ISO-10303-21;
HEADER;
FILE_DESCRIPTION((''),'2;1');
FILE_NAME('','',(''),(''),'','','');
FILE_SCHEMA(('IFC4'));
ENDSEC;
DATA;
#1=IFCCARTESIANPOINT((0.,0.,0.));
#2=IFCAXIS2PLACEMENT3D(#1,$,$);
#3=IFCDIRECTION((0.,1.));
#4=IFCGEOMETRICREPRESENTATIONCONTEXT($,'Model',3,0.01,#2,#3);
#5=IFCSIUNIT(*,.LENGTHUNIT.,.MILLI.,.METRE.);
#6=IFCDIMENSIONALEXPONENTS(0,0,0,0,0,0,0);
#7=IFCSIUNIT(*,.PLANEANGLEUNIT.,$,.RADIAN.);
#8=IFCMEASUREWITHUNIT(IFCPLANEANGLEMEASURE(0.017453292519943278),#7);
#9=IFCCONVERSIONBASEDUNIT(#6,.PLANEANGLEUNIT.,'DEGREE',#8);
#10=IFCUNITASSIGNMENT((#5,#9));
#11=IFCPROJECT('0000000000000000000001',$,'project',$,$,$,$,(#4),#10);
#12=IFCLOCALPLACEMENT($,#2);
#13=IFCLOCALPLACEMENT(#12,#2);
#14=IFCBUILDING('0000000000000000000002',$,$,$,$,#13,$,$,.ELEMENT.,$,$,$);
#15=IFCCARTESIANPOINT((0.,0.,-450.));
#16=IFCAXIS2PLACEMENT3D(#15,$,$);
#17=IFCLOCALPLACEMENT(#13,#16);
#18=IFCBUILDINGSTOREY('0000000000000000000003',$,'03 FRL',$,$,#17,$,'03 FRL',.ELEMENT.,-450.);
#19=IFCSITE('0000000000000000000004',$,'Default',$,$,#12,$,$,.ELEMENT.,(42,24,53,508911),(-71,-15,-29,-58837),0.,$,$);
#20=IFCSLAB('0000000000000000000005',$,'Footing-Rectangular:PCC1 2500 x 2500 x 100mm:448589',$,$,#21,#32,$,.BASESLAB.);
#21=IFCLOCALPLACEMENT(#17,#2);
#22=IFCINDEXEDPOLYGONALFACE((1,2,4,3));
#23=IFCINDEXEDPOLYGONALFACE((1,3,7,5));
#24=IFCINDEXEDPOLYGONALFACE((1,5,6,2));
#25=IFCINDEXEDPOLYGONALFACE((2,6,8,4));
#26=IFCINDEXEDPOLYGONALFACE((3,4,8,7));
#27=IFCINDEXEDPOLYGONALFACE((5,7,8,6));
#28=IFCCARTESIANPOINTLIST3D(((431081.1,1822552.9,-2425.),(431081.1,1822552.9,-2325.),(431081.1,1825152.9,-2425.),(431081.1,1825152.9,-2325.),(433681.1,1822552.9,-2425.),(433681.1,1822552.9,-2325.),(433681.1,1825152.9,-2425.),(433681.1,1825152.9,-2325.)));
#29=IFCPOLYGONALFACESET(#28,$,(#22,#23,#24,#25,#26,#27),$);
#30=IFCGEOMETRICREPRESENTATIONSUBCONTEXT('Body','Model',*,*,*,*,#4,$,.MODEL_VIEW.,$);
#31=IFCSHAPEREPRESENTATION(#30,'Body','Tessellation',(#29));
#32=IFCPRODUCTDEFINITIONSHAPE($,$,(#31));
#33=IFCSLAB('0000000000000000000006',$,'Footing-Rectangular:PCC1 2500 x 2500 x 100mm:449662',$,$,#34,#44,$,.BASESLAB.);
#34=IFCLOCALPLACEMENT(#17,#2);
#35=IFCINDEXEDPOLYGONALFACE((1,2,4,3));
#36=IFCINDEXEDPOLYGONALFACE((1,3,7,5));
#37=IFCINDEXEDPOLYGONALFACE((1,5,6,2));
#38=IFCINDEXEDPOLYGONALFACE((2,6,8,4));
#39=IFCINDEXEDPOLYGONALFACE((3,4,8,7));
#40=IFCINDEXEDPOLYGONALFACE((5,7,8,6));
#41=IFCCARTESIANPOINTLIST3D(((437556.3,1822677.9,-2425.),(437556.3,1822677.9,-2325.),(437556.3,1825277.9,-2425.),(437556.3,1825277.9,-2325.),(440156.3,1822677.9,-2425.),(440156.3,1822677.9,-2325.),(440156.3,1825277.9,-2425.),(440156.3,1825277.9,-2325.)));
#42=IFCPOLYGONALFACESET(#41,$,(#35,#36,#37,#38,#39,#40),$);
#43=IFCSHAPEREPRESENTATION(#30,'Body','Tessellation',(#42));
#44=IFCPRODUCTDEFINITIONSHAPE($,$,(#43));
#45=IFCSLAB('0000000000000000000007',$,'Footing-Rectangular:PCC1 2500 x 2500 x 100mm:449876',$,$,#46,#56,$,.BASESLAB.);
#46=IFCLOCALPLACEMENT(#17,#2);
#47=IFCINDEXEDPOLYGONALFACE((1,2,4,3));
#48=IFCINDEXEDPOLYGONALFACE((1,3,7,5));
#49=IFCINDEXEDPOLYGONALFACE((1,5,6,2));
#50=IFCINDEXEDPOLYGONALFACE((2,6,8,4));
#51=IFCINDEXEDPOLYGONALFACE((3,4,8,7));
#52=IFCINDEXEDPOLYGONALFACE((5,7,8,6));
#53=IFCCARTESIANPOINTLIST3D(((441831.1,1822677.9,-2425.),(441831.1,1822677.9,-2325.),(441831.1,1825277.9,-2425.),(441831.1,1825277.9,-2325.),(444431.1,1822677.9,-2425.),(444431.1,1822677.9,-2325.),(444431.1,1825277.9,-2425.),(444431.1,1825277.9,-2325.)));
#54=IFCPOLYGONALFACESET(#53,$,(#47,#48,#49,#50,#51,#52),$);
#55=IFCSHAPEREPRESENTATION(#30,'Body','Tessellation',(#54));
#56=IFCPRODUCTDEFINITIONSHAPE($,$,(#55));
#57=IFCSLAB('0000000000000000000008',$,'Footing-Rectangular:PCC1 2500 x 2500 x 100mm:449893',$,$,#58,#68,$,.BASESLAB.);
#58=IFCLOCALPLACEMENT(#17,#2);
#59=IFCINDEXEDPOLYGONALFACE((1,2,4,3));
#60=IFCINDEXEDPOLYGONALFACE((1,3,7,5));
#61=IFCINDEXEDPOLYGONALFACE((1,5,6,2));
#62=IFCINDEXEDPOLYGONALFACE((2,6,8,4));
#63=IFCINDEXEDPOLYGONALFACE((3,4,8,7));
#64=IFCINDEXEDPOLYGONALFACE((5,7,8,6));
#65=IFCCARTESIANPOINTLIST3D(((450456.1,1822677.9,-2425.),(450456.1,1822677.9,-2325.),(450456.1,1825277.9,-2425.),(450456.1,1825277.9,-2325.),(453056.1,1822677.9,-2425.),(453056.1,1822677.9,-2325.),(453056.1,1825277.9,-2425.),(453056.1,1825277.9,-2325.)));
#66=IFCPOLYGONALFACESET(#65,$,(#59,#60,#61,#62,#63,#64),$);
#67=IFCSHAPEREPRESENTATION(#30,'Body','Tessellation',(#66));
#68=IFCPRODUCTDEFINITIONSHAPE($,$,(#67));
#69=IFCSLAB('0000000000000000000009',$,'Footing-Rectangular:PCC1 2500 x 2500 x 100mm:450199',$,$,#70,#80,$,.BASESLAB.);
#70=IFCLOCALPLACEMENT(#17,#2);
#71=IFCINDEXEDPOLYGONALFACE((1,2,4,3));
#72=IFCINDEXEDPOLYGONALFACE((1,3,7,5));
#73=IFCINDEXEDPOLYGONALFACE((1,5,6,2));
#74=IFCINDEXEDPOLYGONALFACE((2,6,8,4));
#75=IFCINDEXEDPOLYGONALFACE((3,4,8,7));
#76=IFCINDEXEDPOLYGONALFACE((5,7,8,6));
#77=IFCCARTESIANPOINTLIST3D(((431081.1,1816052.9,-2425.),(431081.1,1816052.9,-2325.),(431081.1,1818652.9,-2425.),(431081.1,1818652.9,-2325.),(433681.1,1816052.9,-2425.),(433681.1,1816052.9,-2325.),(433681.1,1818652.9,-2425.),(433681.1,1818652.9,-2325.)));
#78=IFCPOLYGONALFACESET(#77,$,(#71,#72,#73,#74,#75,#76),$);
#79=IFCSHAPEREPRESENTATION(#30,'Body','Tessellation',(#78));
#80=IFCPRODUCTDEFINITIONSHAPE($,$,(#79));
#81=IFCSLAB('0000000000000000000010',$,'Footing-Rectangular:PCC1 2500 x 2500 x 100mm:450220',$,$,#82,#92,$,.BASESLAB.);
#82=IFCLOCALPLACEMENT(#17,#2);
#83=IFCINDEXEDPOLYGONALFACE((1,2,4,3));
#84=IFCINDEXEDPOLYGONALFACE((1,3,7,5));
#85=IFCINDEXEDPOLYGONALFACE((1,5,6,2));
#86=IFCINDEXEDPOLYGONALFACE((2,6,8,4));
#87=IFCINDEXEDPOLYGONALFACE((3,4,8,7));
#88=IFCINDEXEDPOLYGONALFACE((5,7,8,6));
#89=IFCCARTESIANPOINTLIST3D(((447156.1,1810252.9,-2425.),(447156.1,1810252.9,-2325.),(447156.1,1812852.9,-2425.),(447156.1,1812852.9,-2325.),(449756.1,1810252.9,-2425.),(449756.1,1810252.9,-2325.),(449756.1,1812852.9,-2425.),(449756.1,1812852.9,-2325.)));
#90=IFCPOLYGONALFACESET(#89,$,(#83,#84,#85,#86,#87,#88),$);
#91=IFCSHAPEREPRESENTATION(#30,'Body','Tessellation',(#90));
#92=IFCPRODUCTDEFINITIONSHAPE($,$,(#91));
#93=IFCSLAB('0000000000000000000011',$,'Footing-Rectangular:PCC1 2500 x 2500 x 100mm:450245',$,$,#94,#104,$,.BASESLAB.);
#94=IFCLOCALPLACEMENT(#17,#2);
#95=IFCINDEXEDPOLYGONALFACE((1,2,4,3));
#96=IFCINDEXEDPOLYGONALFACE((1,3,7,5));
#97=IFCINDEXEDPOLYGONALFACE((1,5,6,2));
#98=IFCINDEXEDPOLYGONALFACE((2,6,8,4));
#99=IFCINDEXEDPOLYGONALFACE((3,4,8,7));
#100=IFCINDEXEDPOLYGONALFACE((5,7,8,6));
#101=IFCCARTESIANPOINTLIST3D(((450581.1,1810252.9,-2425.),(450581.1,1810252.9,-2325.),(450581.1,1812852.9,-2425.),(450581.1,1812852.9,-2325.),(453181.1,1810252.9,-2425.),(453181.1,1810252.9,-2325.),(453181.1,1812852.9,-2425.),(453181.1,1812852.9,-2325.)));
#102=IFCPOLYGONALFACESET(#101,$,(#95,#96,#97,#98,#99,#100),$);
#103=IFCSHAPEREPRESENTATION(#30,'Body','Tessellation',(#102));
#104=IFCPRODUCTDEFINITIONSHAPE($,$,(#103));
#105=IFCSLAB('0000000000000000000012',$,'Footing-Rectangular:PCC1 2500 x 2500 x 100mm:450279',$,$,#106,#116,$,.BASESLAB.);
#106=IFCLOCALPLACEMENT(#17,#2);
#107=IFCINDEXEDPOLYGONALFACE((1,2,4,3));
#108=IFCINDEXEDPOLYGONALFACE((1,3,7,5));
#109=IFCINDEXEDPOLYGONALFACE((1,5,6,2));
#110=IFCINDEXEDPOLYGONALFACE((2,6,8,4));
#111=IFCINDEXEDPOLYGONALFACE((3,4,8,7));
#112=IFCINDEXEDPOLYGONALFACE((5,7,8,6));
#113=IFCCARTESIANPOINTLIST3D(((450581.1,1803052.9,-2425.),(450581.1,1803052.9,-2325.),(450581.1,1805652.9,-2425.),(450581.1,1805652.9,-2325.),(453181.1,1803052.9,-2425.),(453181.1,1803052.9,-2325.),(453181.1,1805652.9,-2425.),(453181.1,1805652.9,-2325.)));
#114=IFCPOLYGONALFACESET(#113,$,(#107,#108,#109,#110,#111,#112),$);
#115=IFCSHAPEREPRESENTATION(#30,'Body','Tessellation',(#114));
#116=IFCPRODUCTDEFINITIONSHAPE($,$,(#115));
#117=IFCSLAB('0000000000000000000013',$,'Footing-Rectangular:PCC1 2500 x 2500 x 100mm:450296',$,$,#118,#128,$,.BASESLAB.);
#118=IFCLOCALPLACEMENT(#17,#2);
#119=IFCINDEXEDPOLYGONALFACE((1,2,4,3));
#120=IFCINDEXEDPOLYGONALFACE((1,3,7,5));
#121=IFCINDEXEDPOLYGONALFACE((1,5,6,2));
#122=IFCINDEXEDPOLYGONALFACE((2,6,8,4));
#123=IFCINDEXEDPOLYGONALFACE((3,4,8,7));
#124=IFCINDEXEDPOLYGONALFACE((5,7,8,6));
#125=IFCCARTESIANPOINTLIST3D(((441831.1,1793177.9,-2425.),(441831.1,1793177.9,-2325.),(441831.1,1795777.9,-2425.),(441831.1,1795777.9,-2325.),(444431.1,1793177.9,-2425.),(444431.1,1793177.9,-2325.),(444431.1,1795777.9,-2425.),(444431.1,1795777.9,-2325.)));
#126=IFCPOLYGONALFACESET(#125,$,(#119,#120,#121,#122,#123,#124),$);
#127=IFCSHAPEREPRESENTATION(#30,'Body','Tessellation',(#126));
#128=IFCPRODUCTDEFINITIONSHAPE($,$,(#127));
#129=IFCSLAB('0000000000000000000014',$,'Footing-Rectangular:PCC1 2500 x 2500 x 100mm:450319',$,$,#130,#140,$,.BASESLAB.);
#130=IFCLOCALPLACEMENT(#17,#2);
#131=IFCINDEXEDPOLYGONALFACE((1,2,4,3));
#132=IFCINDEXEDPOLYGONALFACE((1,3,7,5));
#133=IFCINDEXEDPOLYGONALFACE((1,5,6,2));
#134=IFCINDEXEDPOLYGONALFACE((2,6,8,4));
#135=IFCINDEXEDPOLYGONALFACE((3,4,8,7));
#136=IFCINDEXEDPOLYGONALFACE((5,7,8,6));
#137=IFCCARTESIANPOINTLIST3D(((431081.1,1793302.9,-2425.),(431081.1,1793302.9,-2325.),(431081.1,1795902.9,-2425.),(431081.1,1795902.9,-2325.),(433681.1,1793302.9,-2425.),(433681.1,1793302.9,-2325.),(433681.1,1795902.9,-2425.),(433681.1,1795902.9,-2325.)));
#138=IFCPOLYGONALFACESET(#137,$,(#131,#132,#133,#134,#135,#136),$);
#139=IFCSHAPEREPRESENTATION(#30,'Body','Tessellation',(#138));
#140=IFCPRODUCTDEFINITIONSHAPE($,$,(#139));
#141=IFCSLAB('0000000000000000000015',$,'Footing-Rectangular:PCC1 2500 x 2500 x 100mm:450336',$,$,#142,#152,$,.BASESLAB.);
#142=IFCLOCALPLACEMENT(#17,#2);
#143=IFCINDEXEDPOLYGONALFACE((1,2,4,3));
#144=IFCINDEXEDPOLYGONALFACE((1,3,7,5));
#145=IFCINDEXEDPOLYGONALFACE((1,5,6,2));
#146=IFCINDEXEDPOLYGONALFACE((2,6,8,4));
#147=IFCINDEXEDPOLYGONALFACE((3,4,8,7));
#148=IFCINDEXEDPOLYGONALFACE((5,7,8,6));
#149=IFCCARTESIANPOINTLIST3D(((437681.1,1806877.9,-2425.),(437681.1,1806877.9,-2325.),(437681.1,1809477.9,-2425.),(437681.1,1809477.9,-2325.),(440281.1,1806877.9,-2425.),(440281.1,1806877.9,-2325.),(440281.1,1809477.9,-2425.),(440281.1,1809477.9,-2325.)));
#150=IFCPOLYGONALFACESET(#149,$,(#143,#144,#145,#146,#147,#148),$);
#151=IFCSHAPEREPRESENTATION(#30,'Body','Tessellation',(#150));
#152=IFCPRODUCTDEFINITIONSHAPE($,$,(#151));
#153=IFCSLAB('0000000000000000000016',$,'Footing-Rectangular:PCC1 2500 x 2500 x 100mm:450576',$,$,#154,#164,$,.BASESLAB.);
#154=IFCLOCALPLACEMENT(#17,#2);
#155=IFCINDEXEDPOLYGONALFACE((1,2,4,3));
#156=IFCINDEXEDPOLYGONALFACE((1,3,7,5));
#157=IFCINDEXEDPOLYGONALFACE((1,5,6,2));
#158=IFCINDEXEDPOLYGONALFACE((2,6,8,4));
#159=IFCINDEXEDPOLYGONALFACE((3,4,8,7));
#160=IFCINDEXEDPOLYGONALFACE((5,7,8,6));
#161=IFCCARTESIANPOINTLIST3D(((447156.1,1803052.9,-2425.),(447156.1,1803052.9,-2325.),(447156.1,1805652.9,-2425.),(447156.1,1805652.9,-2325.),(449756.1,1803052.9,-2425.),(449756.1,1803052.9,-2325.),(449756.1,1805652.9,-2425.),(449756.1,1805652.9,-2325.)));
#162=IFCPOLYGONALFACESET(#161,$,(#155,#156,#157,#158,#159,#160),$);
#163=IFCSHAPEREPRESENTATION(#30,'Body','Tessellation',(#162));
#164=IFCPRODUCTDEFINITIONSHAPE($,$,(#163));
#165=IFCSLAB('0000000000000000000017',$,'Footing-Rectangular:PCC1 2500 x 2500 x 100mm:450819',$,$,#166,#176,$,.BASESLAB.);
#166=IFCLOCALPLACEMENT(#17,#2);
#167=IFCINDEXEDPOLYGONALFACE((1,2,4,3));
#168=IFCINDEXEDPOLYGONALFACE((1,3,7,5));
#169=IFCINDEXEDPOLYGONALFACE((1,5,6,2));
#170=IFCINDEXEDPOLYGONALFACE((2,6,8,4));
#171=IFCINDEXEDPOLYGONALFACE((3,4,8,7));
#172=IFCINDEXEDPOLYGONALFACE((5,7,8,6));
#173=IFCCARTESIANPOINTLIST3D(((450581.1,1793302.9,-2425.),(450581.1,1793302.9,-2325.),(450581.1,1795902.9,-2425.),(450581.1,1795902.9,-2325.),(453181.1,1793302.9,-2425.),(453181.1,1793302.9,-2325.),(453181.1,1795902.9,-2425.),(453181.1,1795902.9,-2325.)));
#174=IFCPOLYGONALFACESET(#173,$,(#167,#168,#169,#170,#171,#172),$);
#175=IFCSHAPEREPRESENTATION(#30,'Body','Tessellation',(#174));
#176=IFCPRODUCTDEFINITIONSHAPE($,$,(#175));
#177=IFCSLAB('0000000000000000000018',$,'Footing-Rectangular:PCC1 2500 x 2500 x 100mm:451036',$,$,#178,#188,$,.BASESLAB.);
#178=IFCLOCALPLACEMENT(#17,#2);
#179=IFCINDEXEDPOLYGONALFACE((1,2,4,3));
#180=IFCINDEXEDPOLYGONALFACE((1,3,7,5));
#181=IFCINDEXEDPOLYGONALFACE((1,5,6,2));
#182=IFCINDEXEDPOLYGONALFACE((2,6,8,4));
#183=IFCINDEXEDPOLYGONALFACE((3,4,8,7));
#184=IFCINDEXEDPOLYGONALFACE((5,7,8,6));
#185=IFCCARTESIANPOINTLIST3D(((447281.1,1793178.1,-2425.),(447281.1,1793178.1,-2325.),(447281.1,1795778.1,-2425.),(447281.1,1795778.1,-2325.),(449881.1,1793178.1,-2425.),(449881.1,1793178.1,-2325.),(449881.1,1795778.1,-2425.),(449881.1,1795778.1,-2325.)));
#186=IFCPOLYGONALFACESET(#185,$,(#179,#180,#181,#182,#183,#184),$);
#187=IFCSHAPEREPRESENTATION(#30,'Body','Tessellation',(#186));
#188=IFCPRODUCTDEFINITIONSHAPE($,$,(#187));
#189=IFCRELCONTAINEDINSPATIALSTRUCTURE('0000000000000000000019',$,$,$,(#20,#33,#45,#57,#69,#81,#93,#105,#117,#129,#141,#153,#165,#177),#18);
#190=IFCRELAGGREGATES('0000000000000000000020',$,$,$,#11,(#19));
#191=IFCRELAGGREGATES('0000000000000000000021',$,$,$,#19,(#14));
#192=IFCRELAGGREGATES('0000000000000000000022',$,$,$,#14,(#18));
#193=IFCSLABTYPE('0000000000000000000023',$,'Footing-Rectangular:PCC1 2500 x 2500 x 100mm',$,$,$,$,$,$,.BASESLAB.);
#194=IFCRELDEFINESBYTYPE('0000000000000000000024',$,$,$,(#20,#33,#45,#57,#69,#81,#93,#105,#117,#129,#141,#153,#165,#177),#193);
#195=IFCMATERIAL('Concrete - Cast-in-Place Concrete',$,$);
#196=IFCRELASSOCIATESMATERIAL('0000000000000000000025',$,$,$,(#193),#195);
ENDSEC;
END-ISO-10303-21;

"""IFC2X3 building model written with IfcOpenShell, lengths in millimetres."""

from ifc_helpers import new_model, entity, si_unit, converted_unit, direction, frame, frame_2d, origin, place, context, subcontext, project, spatial, rectangle, extrude, material, type_object, element, save


model = new_model("IFC2X3")

# Units and contexts
model_context = context("Model", 3, precision=0.01, world=origin(), true_north=direction((0.0, 1.0)))
body_context = subcontext(model_context, "Body", "Model", "MODEL_VIEW")
ifc_project = project(units=[si_unit("LENGTHUNIT", "METRE", prefix="MILLI"), converted_unit("PLANEANGLEUNIT", "DEGREE", entity("IfcPlaneAngleMeasure", 0.017453292519943278), si_unit("PLANEANGLEUNIT", "RADIAN"), dimensions=[0, 0, 0, 0, 0, 0, 0])], contexts=[model_context])

# Site, building, storey
site_placement = place(None, origin())
site = spatial("IfcSite", under=ifc_project, at=site_placement, Name="Default", CompositionType="ELEMENT", RefLatitude=(42, 24, 53, 508911), RefLongitude=(-71, -15, -29, -58837), RefElevation=0.0)
building_placement = place(site_placement, origin())
building = spatial("IfcBuilding", under=site, at=building_placement, CompositionType="ELEMENT")
storey_placement = place(building_placement, frame((0.0, 0.0, -450.0)))
storey = spatial("IfcBuildingStorey", under=building, at=storey_placement, Name="03 FRL", LongName="03 FRL", CompositionType="ELEMENT", Elevation=-450.0)

# Slabs
ifc_material = material(Name="Concrete - Cast-in-Place Concrete")
slab_type = type_object("IfcSlabType", Name="Footing-Rectangular:PCC1 2500 x 2500 x 100mm", PredefinedType="BASESLAB", material=ifc_material)
slab_1_placement = place(storey_placement, origin())
element("IfcSlab", 1, at=slab_1_placement, inside=storey, type_object=slab_type, Name="Footing-Rectangular:PCC1 2500 x 2500 x 100mm:448589", PredefinedType="BASESLAB", context=body_context, shape_type="SweptSolid", body=[
    extrude(rectangle(XDim=2600.0, YDim=2600.0, at=frame_2d((0.0, 0.0), x_axis=(1.0, 0.0))), frame((432381.1, 1823852.9, -2425.0), z_axis=(0.0, 0.0, 1.0), x_axis=(-1.0, 0.0, 0.0)), (0.0, 0.0, 1.0), 100.0),
])
slab_2_placement = place(storey_placement, origin())
element("IfcSlab", 2, at=slab_2_placement, inside=storey, type_object=slab_type, Name="Footing-Rectangular:PCC1 2500 x 2500 x 100mm:449662", PredefinedType="BASESLAB", context=body_context, shape_type="SweptSolid", body=[
    extrude(rectangle(XDim=2600.0, YDim=2600.0, at=frame_2d((0.0, 0.0), x_axis=(1.0, 0.0))), frame((438856.3, 1823977.9, -2425.0), z_axis=(0.0, 0.0, 1.0), x_axis=(-1.0, 0.0, 0.0)), (0.0, 0.0, 1.0), 100.0),
])
slab_3_placement = place(storey_placement, origin())
element("IfcSlab", 3, at=slab_3_placement, inside=storey, type_object=slab_type, Name="Footing-Rectangular:PCC1 2500 x 2500 x 100mm:449876", PredefinedType="BASESLAB", context=body_context, shape_type="SweptSolid", body=[
    extrude(rectangle(XDim=2600.0, YDim=2600.0, at=frame_2d((0.0, 0.0), x_axis=(1.0, 0.0))), frame((443131.1, 1823977.9, -2425.0), z_axis=(0.0, 0.0, 1.0), x_axis=(-1.0, 0.0, 0.0)), (0.0, 0.0, 1.0), 100.0),
])
slab_4_placement = place(storey_placement, origin())
element("IfcSlab", 4, at=slab_4_placement, inside=storey, type_object=slab_type, Name="Footing-Rectangular:PCC1 2500 x 2500 x 100mm:449893", PredefinedType="BASESLAB", context=body_context, shape_type="SweptSolid", body=[
    extrude(rectangle(XDim=2600.0, YDim=2600.0, at=frame_2d((0.0, 0.0), x_axis=(1.0, 0.0))), frame((451756.1, 1823977.9, -2425.0), z_axis=(0.0, 0.0, 1.0), x_axis=(-1.0, 0.0, 0.0)), (0.0, 0.0, 1.0), 100.0),
])
slab_5_placement = place(storey_placement, origin())
element("IfcSlab", 5, at=slab_5_placement, inside=storey, type_object=slab_type, Name="Footing-Rectangular:PCC1 2500 x 2500 x 100mm:450199", PredefinedType="BASESLAB", context=body_context, shape_type="SweptSolid", body=[
    extrude(rectangle(XDim=2600.0, YDim=2600.0, at=frame_2d((0.0, 0.0), x_axis=(1.0, 0.0))), frame((432381.1, 1817352.9, -2425.0), z_axis=(0.0, 0.0, 1.0), x_axis=(-1.0, 0.0, 0.0)), (0.0, 0.0, 1.0), 100.0),
])
slab_6_placement = place(storey_placement, origin())
element("IfcSlab", 6, at=slab_6_placement, inside=storey, type_object=slab_type, Name="Footing-Rectangular:PCC1 2500 x 2500 x 100mm:450220", PredefinedType="BASESLAB", context=body_context, shape_type="SweptSolid", body=[
    extrude(rectangle(XDim=2600.0, YDim=2600.0, at=frame_2d((0.0, 0.0), x_axis=(1.0, 0.0))), frame((448456.1, 1811552.9, -2425.0), z_axis=(0.0, 0.0, 1.0), x_axis=(-1.0, 0.0, 0.0)), (0.0, 0.0, 1.0), 100.0),
])
slab_7_placement = place(storey_placement, origin())
element("IfcSlab", 7, at=slab_7_placement, inside=storey, type_object=slab_type, Name="Footing-Rectangular:PCC1 2500 x 2500 x 100mm:450245", PredefinedType="BASESLAB", context=body_context, shape_type="SweptSolid", body=[
    extrude(rectangle(XDim=2600.0, YDim=2600.0, at=frame_2d((0.0, 0.0), x_axis=(1.0, 0.0))), frame((451881.1, 1811552.9, -2425.0), z_axis=(0.0, 0.0, 1.0), x_axis=(-1.0, 0.0, 0.0)), (0.0, 0.0, 1.0), 100.0),
])
slab_8_placement = place(storey_placement, origin())
element("IfcSlab", 8, at=slab_8_placement, inside=storey, type_object=slab_type, Name="Footing-Rectangular:PCC1 2500 x 2500 x 100mm:450279", PredefinedType="BASESLAB", context=body_context, shape_type="SweptSolid", body=[
    extrude(rectangle(XDim=2600.0, YDim=2600.0, at=frame_2d((0.0, 0.0), x_axis=(1.0, 0.0))), frame((451881.1, 1804352.9, -2425.0), z_axis=(0.0, 0.0, 1.0), x_axis=(-1.0, 0.0, 0.0)), (0.0, 0.0, 1.0), 100.0),
])
slab_9_placement = place(storey_placement, origin())
element("IfcSlab", 9, at=slab_9_placement, inside=storey, type_object=slab_type, Name="Footing-Rectangular:PCC1 2500 x 2500 x 100mm:450296", PredefinedType="BASESLAB", context=body_context, shape_type="SweptSolid", body=[
    extrude(rectangle(XDim=2600.0, YDim=2600.0, at=frame_2d((0.0, 0.0), x_axis=(1.0, 0.0))), frame((443131.1, 1794477.9, -2425.0), z_axis=(0.0, 0.0, 1.0), x_axis=(-1.0, 0.0, 0.0)), (0.0, 0.0, 1.0), 100.0),
])
slab_10_placement = place(storey_placement, origin())
element("IfcSlab", 10, at=slab_10_placement, inside=storey, type_object=slab_type, Name="Footing-Rectangular:PCC1 2500 x 2500 x 100mm:450319", PredefinedType="BASESLAB", context=body_context, shape_type="SweptSolid", body=[
    extrude(rectangle(XDim=2600.0, YDim=2600.0, at=frame_2d((0.0, 0.0), x_axis=(1.0, 0.0))), frame((432381.1, 1794602.9, -2425.0), z_axis=(0.0, 0.0, 1.0), x_axis=(-1.0, 0.0, 0.0)), (0.0, 0.0, 1.0), 100.0),
])
slab_11_placement = place(storey_placement, origin())
element("IfcSlab", 11, at=slab_11_placement, inside=storey, type_object=slab_type, Name="Footing-Rectangular:PCC1 2500 x 2500 x 100mm:450336", PredefinedType="BASESLAB", context=body_context, shape_type="SweptSolid", body=[
    extrude(rectangle(XDim=2600.0, YDim=2600.0, at=frame_2d((0.0, 0.0), x_axis=(1.0, 0.0))), frame((438981.1, 1808177.9, -2425.0), z_axis=(0.0, 0.0, 1.0), x_axis=(-1.0, 0.0, 0.0)), (0.0, 0.0, 1.0), 100.0),
])
slab_12_placement = place(storey_placement, origin())
element("IfcSlab", 12, at=slab_12_placement, inside=storey, type_object=slab_type, Name="Footing-Rectangular:PCC1 2500 x 2500 x 100mm:450576", PredefinedType="BASESLAB", context=body_context, shape_type="SweptSolid", body=[
    extrude(rectangle(XDim=2600.0, YDim=2600.0, at=frame_2d((0.0, 0.0), x_axis=(1.0, 0.0))), frame((448456.1, 1804352.9, -2425.0), z_axis=(0.0, 0.0, 1.0), x_axis=(-1.0, 0.0, 0.0)), (0.0, 0.0, 1.0), 100.0),
])
slab_13_placement = place(storey_placement, origin())
element("IfcSlab", 13, at=slab_13_placement, inside=storey, type_object=slab_type, Name="Footing-Rectangular:PCC1 2500 x 2500 x 100mm:450819", PredefinedType="BASESLAB", context=body_context, shape_type="SweptSolid", body=[
    extrude(rectangle(XDim=2600.0, YDim=2600.0, at=frame_2d((0.0, 0.0), x_axis=(1.0, 0.0))), frame((451881.1, 1794602.9, -2425.0), z_axis=(0.0, 0.0, 1.0), x_axis=(-1.0, 0.0, 0.0)), (0.0, 0.0, 1.0), 100.0),
])
slab_14_placement = place(storey_placement, origin())
element("IfcSlab", 14, at=slab_14_placement, inside=storey, type_object=slab_type, Name="Footing-Rectangular:PCC1 2500 x 2500 x 100mm:451036", PredefinedType="BASESLAB", context=body_context, shape_type="SweptSolid", body=[
    extrude(rectangle(XDim=2600.0, YDim=2600.0, at=frame_2d((0.0, 0.0), x_axis=(1.0, 0.0))), frame((448581.1, 1794478.1, -2425.0), z_axis=(0.0, 0.0, 1.0), x_axis=(-1.0, 0.0, 0.0)), (0.0, 0.0, 1.0), 100.0),
])

save(model, "model.ifc")
